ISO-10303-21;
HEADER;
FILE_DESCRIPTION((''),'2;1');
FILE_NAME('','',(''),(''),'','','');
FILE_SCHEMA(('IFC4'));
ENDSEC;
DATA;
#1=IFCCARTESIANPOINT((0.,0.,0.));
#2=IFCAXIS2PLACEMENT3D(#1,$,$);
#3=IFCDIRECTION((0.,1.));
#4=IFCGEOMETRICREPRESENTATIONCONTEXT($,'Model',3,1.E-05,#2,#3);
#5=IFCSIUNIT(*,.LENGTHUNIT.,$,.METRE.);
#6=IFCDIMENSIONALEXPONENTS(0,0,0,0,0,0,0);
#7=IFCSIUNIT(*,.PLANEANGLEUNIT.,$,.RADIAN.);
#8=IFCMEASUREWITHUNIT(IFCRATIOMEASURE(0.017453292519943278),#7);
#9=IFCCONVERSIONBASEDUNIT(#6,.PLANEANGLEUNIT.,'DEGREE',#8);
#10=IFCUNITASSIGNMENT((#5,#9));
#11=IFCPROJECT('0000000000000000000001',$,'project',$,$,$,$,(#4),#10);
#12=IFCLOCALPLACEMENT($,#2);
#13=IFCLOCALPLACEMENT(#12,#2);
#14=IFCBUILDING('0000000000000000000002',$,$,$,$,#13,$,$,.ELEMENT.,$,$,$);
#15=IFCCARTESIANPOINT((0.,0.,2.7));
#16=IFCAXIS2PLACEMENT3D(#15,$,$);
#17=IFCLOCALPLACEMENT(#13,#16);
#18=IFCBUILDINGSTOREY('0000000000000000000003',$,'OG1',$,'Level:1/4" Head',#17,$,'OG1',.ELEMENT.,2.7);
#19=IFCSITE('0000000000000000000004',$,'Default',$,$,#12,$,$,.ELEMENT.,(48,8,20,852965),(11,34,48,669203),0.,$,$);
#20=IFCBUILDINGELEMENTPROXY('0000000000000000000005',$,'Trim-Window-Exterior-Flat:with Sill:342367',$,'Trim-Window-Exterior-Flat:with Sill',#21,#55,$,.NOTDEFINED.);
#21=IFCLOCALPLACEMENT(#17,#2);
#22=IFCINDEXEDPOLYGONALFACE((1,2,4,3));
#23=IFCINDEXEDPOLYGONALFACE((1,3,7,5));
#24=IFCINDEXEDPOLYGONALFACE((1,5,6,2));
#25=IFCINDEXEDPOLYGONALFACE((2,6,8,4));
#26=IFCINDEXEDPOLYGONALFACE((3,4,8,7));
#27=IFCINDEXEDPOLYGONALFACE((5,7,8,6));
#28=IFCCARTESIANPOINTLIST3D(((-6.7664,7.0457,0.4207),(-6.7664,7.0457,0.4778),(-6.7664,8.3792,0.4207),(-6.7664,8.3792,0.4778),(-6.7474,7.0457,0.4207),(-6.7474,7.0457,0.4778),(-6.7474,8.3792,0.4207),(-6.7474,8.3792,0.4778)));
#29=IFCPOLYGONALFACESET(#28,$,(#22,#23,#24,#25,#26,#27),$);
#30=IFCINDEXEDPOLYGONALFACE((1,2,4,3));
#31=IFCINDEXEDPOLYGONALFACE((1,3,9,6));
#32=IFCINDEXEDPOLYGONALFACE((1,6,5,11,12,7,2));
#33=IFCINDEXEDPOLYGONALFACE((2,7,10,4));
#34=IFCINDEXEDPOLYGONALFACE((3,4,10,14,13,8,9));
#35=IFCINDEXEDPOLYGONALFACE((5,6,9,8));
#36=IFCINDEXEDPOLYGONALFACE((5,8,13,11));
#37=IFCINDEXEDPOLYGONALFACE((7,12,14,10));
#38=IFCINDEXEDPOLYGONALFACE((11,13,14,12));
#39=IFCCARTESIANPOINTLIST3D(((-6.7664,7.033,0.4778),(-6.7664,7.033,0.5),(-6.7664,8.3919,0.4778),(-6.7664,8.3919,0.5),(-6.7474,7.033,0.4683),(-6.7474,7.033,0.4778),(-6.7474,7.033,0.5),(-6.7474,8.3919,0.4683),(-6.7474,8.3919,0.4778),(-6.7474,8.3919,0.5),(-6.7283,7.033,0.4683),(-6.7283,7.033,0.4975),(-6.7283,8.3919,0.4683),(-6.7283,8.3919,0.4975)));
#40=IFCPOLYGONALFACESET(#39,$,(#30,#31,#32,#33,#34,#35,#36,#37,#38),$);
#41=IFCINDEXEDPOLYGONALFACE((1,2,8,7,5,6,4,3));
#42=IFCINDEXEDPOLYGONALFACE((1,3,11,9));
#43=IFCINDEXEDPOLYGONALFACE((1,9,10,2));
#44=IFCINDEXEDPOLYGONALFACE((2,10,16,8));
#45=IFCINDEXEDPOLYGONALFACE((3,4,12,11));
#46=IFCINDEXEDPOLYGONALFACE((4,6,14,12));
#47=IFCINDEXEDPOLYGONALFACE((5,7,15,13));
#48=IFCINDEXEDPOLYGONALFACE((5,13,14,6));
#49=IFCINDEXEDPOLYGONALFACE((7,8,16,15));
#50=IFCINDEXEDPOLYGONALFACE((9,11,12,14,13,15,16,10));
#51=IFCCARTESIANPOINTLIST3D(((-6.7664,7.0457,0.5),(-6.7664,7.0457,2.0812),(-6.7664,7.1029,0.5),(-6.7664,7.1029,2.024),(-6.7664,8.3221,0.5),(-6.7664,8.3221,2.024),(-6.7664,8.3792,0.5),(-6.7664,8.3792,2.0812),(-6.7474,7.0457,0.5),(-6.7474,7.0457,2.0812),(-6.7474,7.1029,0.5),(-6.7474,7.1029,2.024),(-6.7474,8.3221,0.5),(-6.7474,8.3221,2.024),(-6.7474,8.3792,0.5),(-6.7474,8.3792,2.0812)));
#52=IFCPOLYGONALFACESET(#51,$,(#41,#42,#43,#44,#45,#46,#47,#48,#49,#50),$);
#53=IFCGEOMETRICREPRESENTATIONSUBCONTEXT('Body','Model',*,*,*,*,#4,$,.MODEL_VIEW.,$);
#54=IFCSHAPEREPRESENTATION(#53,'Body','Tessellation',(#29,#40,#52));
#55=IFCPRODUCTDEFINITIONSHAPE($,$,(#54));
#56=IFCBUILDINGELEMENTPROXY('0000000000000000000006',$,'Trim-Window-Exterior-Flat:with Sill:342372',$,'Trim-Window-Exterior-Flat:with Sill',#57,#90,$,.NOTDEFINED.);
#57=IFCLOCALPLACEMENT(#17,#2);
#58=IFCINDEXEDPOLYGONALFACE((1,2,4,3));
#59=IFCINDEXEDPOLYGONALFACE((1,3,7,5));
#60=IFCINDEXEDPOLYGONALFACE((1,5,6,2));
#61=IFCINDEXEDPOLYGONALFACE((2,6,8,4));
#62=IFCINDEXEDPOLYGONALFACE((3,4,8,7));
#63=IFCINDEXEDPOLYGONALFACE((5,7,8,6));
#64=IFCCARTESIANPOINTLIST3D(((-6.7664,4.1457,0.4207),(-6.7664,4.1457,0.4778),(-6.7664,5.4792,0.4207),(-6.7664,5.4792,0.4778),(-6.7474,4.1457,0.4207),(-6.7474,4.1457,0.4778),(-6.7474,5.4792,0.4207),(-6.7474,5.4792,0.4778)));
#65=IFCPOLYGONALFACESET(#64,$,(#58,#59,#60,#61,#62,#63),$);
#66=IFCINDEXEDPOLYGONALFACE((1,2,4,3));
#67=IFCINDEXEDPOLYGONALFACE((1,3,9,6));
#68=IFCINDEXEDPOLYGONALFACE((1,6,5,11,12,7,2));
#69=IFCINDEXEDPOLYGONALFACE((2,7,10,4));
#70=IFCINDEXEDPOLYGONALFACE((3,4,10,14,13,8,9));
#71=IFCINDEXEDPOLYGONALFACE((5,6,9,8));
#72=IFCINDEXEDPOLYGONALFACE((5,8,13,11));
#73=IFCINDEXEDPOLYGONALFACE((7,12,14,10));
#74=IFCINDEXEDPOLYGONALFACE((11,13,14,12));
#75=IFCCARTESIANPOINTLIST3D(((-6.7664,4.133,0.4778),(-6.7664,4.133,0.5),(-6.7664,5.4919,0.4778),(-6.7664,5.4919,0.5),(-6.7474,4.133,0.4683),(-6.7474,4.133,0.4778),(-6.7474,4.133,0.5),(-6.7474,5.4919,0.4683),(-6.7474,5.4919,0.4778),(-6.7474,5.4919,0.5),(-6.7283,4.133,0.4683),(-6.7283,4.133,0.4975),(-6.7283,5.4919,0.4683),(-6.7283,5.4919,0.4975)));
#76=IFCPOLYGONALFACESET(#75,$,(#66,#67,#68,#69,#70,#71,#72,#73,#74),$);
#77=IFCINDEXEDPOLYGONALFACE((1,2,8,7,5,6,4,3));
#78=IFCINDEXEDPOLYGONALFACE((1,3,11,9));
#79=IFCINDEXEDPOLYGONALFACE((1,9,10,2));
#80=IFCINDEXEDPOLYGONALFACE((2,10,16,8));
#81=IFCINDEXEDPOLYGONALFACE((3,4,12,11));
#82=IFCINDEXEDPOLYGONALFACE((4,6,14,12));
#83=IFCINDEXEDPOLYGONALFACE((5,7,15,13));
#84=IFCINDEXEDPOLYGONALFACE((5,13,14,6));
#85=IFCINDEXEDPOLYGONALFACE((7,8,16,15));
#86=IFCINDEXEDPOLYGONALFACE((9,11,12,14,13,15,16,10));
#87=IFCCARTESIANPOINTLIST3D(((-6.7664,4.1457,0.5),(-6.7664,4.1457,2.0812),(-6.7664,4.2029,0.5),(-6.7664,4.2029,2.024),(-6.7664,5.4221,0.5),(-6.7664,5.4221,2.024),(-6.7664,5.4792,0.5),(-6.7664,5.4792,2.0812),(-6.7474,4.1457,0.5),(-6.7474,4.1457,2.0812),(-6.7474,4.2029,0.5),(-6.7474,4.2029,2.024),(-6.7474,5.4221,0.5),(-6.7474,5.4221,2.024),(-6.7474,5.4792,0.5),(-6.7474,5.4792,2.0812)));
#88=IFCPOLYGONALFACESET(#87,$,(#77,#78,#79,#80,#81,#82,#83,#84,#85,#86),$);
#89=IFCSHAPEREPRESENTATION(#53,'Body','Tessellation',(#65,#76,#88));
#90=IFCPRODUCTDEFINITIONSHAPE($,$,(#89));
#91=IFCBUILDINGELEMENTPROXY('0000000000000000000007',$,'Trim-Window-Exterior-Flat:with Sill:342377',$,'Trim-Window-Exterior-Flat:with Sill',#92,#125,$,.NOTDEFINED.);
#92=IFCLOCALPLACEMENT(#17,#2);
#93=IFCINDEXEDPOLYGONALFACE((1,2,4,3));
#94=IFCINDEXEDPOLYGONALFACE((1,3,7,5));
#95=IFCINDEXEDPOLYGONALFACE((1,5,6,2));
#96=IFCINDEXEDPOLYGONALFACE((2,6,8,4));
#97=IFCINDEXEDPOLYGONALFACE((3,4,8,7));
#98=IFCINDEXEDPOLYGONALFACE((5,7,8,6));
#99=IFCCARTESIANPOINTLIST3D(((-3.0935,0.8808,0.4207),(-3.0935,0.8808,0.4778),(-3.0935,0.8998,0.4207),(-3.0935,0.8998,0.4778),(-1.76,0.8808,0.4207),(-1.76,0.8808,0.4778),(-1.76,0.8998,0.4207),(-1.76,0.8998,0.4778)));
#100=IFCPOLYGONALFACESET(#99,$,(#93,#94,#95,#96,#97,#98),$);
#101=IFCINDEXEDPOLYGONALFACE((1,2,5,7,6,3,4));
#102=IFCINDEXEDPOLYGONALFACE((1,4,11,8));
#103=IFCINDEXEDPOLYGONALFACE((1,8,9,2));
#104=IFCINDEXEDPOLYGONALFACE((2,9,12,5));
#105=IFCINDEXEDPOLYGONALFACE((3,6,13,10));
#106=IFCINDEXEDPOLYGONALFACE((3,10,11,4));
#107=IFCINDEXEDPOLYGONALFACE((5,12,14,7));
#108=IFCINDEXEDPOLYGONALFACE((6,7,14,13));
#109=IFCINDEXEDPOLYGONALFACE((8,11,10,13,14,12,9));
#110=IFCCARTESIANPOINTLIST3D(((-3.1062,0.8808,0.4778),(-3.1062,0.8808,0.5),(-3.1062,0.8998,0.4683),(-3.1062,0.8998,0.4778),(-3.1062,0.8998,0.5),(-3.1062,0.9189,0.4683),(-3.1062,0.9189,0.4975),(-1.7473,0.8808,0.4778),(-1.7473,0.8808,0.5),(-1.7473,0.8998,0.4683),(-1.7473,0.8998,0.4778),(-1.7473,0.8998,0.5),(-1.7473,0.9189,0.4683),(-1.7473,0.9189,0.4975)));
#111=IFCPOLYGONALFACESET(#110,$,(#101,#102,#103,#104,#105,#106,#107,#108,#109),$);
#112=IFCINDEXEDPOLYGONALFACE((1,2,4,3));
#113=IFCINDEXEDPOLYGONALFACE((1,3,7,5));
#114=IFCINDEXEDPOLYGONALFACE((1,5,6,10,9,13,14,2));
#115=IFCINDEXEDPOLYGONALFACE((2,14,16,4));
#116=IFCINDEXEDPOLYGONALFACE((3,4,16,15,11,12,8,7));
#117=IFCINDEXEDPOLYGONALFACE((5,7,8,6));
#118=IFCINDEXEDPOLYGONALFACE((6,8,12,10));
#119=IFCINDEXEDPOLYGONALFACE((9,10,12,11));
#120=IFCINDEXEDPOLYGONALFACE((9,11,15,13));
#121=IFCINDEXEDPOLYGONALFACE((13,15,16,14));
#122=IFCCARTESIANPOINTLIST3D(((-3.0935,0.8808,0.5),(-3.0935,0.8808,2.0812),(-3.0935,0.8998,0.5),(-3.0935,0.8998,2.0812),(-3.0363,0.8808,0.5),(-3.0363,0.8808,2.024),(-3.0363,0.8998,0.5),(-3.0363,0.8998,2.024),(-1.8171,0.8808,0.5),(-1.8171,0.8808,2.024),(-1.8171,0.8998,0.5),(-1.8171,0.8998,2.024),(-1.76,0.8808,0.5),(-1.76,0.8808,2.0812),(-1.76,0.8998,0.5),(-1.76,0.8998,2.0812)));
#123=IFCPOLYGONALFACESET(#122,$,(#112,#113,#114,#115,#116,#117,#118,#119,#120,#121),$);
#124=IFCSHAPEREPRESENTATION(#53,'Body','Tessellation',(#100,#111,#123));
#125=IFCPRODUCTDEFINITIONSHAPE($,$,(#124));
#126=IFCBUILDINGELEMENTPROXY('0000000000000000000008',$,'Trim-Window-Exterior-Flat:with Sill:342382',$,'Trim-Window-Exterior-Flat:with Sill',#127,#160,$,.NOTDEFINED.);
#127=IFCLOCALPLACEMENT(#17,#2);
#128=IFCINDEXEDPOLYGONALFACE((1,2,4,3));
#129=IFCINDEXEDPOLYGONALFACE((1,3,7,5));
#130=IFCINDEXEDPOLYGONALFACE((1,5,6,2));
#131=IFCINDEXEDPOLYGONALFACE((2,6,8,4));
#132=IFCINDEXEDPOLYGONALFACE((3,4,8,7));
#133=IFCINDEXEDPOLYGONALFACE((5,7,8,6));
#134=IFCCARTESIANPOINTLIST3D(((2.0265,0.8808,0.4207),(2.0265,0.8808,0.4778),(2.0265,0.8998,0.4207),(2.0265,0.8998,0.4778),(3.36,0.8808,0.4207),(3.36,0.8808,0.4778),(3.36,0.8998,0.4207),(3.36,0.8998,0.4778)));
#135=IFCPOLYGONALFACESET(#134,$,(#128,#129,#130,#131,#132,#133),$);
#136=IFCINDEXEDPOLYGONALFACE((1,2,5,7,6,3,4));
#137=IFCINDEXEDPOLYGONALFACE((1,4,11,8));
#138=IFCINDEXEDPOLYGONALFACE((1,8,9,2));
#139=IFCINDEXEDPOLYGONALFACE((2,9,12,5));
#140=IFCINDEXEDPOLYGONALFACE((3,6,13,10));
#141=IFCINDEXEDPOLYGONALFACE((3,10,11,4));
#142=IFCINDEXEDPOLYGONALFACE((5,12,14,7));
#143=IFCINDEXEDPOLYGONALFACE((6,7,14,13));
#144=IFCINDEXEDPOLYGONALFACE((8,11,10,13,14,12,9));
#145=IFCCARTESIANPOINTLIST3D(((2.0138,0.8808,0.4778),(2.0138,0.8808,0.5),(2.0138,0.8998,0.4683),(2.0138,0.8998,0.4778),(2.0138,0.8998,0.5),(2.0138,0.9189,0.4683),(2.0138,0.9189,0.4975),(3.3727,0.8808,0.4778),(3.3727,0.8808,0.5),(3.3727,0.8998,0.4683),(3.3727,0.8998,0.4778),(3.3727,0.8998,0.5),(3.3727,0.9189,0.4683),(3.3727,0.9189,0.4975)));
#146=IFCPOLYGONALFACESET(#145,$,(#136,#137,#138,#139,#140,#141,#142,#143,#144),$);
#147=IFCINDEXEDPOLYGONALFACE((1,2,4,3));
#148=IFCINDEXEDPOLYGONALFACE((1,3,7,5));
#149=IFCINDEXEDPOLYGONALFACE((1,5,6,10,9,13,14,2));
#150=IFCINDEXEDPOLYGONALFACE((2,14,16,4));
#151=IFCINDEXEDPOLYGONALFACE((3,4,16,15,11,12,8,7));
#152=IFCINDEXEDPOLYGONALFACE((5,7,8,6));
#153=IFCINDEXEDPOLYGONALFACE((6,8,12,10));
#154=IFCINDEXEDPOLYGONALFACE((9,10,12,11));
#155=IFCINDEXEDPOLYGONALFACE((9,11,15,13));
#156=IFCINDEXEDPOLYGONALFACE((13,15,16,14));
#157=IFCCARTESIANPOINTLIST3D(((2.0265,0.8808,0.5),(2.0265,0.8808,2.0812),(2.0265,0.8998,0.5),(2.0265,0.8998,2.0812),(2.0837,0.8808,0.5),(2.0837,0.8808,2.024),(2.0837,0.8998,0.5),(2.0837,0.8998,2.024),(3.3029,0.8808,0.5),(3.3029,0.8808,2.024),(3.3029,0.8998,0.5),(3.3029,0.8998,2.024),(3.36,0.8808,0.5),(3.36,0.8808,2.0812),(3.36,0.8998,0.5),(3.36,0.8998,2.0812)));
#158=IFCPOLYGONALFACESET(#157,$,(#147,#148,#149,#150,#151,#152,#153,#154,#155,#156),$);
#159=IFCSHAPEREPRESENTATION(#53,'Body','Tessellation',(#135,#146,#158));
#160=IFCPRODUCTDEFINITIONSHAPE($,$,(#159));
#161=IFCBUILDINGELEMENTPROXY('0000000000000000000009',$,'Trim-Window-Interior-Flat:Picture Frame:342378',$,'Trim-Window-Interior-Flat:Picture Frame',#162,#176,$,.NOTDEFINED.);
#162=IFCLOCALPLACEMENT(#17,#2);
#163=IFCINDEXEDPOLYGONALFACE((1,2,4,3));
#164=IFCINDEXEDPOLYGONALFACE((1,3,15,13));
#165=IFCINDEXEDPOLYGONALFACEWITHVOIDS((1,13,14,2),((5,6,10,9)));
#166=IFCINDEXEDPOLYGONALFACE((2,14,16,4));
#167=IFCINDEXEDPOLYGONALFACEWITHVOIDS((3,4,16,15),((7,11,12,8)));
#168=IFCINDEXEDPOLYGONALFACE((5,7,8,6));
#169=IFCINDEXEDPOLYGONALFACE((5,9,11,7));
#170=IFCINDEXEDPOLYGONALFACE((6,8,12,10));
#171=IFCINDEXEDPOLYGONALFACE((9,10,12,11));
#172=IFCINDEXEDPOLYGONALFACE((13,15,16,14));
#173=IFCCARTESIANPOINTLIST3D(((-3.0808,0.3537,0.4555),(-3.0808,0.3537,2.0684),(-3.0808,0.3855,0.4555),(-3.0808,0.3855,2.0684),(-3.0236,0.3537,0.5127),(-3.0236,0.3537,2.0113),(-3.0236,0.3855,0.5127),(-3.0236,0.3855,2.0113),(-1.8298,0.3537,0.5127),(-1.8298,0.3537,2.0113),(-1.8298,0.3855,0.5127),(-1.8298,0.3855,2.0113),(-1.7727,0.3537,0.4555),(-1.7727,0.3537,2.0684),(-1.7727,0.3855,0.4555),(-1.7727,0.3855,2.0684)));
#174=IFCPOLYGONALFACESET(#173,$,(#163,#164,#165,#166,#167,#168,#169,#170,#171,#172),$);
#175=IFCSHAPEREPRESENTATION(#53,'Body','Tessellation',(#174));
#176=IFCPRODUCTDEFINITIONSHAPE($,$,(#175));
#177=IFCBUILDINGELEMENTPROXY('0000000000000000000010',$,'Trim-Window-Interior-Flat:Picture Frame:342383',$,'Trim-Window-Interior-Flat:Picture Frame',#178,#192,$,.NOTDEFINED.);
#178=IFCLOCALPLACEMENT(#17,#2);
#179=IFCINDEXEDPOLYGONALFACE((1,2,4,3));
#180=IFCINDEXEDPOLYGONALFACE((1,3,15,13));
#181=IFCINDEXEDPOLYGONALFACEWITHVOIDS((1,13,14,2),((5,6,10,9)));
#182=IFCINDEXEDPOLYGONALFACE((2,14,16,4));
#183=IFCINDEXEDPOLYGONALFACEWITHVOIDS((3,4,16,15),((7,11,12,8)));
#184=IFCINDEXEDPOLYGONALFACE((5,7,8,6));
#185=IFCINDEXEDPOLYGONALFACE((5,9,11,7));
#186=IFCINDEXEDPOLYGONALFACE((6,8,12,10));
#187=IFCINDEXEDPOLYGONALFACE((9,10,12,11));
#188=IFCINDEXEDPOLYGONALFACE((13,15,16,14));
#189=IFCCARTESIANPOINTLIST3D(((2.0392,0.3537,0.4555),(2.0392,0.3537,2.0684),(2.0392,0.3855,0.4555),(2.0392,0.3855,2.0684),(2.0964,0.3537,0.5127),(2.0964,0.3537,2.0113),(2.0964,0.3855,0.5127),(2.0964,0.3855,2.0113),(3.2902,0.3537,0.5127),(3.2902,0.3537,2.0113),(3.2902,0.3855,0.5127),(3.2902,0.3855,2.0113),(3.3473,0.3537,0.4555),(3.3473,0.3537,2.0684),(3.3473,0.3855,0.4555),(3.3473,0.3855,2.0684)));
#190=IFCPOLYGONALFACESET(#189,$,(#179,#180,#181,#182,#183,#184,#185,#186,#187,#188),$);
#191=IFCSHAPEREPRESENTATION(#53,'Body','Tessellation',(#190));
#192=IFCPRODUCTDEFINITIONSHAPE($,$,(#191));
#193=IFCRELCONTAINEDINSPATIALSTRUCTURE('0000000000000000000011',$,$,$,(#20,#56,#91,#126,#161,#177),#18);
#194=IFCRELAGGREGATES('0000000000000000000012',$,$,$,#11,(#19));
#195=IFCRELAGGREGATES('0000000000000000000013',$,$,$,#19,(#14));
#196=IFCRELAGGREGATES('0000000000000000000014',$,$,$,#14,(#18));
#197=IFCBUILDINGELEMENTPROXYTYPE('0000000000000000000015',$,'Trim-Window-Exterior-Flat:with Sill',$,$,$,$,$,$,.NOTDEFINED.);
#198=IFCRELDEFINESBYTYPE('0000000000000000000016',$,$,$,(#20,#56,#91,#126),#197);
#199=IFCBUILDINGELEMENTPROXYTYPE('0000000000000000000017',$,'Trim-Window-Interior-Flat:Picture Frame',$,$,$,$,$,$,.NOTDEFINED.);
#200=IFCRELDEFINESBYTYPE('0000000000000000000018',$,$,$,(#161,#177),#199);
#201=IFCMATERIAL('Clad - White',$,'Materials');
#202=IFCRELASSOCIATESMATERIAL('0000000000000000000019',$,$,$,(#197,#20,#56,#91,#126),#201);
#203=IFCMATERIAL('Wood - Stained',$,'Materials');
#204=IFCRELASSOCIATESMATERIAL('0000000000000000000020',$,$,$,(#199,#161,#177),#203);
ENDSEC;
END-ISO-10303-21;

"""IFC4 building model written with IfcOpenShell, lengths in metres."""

from ifc_helpers import new_model, entity, si_unit, converted_unit, direction, frame, origin, place, context, subcontext, project, spatial, indexed_curve, outline, extrude, source, transform, mapped, material, type_object, type_shapes, element, save


model = new_model("IFC4")

# Units and contexts
model_context = context("Model", 3, precision=1e-05, world=origin(), true_north=direction((0.0, 1.0)))
body_context = subcontext(model_context, "Body", "Model", "MODEL_VIEW")
ifc_project = project(units=[si_unit("LENGTHUNIT", "METRE"), converted_unit("PLANEANGLEUNIT", "DEGREE", entity("IfcRatioMeasure", 0.017453292519943278), si_unit("PLANEANGLEUNIT", "RADIAN"), dimensions=[0, 0, 0, 0, 0, 0, 0])], contexts=[model_context])

# Site, building, storey
site_placement = place(None, origin())
site = spatial("IfcSite", under=ifc_project, at=site_placement, Name="Default", CompositionType="ELEMENT", RefLatitude=(48, 8, 20, 852965), RefLongitude=(11, 34, 48, 669203), RefElevation=0.0)
building_placement = place(site_placement, origin())
building = spatial("IfcBuilding", under=site, at=building_placement, CompositionType="ELEMENT")
storey_placement = place(building_placement, frame((0.0, 0.0, 2.7)))
storey = spatial("IfcBuildingStorey", under=building, at=storey_placement, Name="OG1", ObjectType="Level:1/4\" Head", LongName="OG1", CompositionType="ELEMENT", Elevation=2.7)

# Building element proxies
ifc_material_1 = material(Name="Clad - White", Category="Materials")
ifc_material_2 = material(Name="Wood - Stained", Category="Materials")
building_element_proxy_type_1 = type_object("IfcBuildingElementProxyType", Name="Trim-Window-Exterior-Flat:with Sill", PredefinedType="NOTDEFINED", material=ifc_material_1)
shared_shape_1 = source(origin(), body_context, "Body", "SweptSolid", [
    extrude(outline(indexed_curve([(-0.6667, -0.0286), (0.6667, -0.0286), (0.6667, 0.0286), (-0.6667, 0.0286), (-0.6667, -0.0286)], self_intersect=False)), frame((0.0, -1.5748, 0.0), z_axis=(0.0, 0.0, 1.0), x_axis=(-1.0, 0.0, 0.0)), (0.0, 0.0, 1.0), 0.019),
    extrude(outline(indexed_curve([(-0.019, -0.016), (0.0, -0.016), (0.0, -0.0064), (0.019, -0.0064), (0.019, 0.0158), (0.0, 0.0158), (-0.019, 0.0133), (-0.019, -0.016)], self_intersect=False)), frame((-0.6794, -1.5398, 0.019), z_axis=(1.0, 0.0, 0.0), x_axis=(0.0, 0.0, -1.0)), (0.0, 0.0, 1.0), 1.3589),
    extrude(outline(indexed_curve([(-0.8049, -0.6667), (0.7763, -0.6667), (0.7763, -0.6096), (-0.7477, -0.6096), (-0.7477, 0.6096), (0.7763, 0.6096), (0.7763, 0.6667), (-0.8049, 0.6667), (-0.8049, -0.6667)], self_intersect=False)), frame((0.0, -0.7477, 0.0), z_axis=(0.0, 0.0, 1.0), x_axis=(0.0, -1.0, 0.0)), (0.0, 0.0, 1.0), 0.019),
])
type_shapes(building_element_proxy_type_1, [shared_shape_1])
for number, where, z_axis, x_axis, name in (
    (1, (-6.7664, 7.7125, 2.024), (1.0, 0.0, 0.0), (0.0, 1.0, 0.0), "Trim-Window-Exterior-Flat:with Sill:342367"),
    (2, (-6.7664, 4.8125, 2.024), (1.0, 0.0, 0.0), (0.0, 1.0, 0.0), "Trim-Window-Exterior-Flat:with Sill:342372"),
    (3, (-2.4267, 0.8808, 2.024), (0.0, 1.0, 0.0), (-1.0, 0.0, 0.0), "Trim-Window-Exterior-Flat:with Sill:342377"),
    (4, (2.6933, 0.8808, 2.024), (0.0, 1.0, 0.0), (-1.0, 0.0, 0.0), "Trim-Window-Exterior-Flat:with Sill:342382"),
):
    element("IfcBuildingElementProxy", number, at=place(storey_placement, frame(where, z_axis=z_axis, x_axis=x_axis)), inside=storey, type_object=building_element_proxy_type_1, material=ifc_material_1, Name=name, ObjectType="Trim-Window-Exterior-Flat:with Sill", PredefinedType="NOTDEFINED", context=body_context, shape_type="MappedRepresentation", body=[
        mapped(shared_shape_1, transform((0.0, 0.0, 0.0), scale=1.0)),
    ])
building_element_proxy_type_2 = type_object("IfcBuildingElementProxyType", Name="Trim-Window-Interior-Flat:Picture Frame", PredefinedType="NOTDEFINED", material=ifc_material_2)
shared_shape_2 = source(origin(), body_context, "Body", "SweptSolid", [
    extrude(outline(indexed_curve([(-0.654, -0.8064), (0.654, -0.8064), (0.654, 0.8064), (-0.654, 0.8064), (-0.654, -0.8064)], self_intersect=False), holes=[indexed_curve([(-0.5969, -0.7493), (-0.5969, 0.7493), (0.5969, 0.7493), (0.5969, -0.7493), (-0.5969, -0.7493)], self_intersect=False)]), frame((0.0, -0.762, 0.0), z_axis=(0.0, 0.0, 1.0), x_axis=(-1.0, 0.0, 0.0)), (0.0, 0.0, 1.0), 0.0317),
])
type_shapes(building_element_proxy_type_2, [shared_shape_2])
for number, where, z_axis, x_axis, name in (
    (5, (-2.4267, 0.3855, 2.024), (0.0, -1.0, 0.0), (1.0, 0.0, 0.0), "Trim-Window-Interior-Flat:Picture Frame:342378"),
    (6, (2.6933, 0.3855, 2.024), (0.0, -1.0, 0.0), (1.0, 0.0, 0.0), "Trim-Window-Interior-Flat:Picture Frame:342383"),
):
    element("IfcBuildingElementProxy", number, at=place(storey_placement, frame(where, z_axis=z_axis, x_axis=x_axis)), inside=storey, type_object=building_element_proxy_type_2, material=ifc_material_2, Name=name, ObjectType="Trim-Window-Interior-Flat:Picture Frame", PredefinedType="NOTDEFINED", context=body_context, shape_type="MappedRepresentation", body=[
        mapped(shared_shape_2, transform((0.0, 0.0, 0.0), scale=1.0)),
    ])

save(model, "model.ifc")
